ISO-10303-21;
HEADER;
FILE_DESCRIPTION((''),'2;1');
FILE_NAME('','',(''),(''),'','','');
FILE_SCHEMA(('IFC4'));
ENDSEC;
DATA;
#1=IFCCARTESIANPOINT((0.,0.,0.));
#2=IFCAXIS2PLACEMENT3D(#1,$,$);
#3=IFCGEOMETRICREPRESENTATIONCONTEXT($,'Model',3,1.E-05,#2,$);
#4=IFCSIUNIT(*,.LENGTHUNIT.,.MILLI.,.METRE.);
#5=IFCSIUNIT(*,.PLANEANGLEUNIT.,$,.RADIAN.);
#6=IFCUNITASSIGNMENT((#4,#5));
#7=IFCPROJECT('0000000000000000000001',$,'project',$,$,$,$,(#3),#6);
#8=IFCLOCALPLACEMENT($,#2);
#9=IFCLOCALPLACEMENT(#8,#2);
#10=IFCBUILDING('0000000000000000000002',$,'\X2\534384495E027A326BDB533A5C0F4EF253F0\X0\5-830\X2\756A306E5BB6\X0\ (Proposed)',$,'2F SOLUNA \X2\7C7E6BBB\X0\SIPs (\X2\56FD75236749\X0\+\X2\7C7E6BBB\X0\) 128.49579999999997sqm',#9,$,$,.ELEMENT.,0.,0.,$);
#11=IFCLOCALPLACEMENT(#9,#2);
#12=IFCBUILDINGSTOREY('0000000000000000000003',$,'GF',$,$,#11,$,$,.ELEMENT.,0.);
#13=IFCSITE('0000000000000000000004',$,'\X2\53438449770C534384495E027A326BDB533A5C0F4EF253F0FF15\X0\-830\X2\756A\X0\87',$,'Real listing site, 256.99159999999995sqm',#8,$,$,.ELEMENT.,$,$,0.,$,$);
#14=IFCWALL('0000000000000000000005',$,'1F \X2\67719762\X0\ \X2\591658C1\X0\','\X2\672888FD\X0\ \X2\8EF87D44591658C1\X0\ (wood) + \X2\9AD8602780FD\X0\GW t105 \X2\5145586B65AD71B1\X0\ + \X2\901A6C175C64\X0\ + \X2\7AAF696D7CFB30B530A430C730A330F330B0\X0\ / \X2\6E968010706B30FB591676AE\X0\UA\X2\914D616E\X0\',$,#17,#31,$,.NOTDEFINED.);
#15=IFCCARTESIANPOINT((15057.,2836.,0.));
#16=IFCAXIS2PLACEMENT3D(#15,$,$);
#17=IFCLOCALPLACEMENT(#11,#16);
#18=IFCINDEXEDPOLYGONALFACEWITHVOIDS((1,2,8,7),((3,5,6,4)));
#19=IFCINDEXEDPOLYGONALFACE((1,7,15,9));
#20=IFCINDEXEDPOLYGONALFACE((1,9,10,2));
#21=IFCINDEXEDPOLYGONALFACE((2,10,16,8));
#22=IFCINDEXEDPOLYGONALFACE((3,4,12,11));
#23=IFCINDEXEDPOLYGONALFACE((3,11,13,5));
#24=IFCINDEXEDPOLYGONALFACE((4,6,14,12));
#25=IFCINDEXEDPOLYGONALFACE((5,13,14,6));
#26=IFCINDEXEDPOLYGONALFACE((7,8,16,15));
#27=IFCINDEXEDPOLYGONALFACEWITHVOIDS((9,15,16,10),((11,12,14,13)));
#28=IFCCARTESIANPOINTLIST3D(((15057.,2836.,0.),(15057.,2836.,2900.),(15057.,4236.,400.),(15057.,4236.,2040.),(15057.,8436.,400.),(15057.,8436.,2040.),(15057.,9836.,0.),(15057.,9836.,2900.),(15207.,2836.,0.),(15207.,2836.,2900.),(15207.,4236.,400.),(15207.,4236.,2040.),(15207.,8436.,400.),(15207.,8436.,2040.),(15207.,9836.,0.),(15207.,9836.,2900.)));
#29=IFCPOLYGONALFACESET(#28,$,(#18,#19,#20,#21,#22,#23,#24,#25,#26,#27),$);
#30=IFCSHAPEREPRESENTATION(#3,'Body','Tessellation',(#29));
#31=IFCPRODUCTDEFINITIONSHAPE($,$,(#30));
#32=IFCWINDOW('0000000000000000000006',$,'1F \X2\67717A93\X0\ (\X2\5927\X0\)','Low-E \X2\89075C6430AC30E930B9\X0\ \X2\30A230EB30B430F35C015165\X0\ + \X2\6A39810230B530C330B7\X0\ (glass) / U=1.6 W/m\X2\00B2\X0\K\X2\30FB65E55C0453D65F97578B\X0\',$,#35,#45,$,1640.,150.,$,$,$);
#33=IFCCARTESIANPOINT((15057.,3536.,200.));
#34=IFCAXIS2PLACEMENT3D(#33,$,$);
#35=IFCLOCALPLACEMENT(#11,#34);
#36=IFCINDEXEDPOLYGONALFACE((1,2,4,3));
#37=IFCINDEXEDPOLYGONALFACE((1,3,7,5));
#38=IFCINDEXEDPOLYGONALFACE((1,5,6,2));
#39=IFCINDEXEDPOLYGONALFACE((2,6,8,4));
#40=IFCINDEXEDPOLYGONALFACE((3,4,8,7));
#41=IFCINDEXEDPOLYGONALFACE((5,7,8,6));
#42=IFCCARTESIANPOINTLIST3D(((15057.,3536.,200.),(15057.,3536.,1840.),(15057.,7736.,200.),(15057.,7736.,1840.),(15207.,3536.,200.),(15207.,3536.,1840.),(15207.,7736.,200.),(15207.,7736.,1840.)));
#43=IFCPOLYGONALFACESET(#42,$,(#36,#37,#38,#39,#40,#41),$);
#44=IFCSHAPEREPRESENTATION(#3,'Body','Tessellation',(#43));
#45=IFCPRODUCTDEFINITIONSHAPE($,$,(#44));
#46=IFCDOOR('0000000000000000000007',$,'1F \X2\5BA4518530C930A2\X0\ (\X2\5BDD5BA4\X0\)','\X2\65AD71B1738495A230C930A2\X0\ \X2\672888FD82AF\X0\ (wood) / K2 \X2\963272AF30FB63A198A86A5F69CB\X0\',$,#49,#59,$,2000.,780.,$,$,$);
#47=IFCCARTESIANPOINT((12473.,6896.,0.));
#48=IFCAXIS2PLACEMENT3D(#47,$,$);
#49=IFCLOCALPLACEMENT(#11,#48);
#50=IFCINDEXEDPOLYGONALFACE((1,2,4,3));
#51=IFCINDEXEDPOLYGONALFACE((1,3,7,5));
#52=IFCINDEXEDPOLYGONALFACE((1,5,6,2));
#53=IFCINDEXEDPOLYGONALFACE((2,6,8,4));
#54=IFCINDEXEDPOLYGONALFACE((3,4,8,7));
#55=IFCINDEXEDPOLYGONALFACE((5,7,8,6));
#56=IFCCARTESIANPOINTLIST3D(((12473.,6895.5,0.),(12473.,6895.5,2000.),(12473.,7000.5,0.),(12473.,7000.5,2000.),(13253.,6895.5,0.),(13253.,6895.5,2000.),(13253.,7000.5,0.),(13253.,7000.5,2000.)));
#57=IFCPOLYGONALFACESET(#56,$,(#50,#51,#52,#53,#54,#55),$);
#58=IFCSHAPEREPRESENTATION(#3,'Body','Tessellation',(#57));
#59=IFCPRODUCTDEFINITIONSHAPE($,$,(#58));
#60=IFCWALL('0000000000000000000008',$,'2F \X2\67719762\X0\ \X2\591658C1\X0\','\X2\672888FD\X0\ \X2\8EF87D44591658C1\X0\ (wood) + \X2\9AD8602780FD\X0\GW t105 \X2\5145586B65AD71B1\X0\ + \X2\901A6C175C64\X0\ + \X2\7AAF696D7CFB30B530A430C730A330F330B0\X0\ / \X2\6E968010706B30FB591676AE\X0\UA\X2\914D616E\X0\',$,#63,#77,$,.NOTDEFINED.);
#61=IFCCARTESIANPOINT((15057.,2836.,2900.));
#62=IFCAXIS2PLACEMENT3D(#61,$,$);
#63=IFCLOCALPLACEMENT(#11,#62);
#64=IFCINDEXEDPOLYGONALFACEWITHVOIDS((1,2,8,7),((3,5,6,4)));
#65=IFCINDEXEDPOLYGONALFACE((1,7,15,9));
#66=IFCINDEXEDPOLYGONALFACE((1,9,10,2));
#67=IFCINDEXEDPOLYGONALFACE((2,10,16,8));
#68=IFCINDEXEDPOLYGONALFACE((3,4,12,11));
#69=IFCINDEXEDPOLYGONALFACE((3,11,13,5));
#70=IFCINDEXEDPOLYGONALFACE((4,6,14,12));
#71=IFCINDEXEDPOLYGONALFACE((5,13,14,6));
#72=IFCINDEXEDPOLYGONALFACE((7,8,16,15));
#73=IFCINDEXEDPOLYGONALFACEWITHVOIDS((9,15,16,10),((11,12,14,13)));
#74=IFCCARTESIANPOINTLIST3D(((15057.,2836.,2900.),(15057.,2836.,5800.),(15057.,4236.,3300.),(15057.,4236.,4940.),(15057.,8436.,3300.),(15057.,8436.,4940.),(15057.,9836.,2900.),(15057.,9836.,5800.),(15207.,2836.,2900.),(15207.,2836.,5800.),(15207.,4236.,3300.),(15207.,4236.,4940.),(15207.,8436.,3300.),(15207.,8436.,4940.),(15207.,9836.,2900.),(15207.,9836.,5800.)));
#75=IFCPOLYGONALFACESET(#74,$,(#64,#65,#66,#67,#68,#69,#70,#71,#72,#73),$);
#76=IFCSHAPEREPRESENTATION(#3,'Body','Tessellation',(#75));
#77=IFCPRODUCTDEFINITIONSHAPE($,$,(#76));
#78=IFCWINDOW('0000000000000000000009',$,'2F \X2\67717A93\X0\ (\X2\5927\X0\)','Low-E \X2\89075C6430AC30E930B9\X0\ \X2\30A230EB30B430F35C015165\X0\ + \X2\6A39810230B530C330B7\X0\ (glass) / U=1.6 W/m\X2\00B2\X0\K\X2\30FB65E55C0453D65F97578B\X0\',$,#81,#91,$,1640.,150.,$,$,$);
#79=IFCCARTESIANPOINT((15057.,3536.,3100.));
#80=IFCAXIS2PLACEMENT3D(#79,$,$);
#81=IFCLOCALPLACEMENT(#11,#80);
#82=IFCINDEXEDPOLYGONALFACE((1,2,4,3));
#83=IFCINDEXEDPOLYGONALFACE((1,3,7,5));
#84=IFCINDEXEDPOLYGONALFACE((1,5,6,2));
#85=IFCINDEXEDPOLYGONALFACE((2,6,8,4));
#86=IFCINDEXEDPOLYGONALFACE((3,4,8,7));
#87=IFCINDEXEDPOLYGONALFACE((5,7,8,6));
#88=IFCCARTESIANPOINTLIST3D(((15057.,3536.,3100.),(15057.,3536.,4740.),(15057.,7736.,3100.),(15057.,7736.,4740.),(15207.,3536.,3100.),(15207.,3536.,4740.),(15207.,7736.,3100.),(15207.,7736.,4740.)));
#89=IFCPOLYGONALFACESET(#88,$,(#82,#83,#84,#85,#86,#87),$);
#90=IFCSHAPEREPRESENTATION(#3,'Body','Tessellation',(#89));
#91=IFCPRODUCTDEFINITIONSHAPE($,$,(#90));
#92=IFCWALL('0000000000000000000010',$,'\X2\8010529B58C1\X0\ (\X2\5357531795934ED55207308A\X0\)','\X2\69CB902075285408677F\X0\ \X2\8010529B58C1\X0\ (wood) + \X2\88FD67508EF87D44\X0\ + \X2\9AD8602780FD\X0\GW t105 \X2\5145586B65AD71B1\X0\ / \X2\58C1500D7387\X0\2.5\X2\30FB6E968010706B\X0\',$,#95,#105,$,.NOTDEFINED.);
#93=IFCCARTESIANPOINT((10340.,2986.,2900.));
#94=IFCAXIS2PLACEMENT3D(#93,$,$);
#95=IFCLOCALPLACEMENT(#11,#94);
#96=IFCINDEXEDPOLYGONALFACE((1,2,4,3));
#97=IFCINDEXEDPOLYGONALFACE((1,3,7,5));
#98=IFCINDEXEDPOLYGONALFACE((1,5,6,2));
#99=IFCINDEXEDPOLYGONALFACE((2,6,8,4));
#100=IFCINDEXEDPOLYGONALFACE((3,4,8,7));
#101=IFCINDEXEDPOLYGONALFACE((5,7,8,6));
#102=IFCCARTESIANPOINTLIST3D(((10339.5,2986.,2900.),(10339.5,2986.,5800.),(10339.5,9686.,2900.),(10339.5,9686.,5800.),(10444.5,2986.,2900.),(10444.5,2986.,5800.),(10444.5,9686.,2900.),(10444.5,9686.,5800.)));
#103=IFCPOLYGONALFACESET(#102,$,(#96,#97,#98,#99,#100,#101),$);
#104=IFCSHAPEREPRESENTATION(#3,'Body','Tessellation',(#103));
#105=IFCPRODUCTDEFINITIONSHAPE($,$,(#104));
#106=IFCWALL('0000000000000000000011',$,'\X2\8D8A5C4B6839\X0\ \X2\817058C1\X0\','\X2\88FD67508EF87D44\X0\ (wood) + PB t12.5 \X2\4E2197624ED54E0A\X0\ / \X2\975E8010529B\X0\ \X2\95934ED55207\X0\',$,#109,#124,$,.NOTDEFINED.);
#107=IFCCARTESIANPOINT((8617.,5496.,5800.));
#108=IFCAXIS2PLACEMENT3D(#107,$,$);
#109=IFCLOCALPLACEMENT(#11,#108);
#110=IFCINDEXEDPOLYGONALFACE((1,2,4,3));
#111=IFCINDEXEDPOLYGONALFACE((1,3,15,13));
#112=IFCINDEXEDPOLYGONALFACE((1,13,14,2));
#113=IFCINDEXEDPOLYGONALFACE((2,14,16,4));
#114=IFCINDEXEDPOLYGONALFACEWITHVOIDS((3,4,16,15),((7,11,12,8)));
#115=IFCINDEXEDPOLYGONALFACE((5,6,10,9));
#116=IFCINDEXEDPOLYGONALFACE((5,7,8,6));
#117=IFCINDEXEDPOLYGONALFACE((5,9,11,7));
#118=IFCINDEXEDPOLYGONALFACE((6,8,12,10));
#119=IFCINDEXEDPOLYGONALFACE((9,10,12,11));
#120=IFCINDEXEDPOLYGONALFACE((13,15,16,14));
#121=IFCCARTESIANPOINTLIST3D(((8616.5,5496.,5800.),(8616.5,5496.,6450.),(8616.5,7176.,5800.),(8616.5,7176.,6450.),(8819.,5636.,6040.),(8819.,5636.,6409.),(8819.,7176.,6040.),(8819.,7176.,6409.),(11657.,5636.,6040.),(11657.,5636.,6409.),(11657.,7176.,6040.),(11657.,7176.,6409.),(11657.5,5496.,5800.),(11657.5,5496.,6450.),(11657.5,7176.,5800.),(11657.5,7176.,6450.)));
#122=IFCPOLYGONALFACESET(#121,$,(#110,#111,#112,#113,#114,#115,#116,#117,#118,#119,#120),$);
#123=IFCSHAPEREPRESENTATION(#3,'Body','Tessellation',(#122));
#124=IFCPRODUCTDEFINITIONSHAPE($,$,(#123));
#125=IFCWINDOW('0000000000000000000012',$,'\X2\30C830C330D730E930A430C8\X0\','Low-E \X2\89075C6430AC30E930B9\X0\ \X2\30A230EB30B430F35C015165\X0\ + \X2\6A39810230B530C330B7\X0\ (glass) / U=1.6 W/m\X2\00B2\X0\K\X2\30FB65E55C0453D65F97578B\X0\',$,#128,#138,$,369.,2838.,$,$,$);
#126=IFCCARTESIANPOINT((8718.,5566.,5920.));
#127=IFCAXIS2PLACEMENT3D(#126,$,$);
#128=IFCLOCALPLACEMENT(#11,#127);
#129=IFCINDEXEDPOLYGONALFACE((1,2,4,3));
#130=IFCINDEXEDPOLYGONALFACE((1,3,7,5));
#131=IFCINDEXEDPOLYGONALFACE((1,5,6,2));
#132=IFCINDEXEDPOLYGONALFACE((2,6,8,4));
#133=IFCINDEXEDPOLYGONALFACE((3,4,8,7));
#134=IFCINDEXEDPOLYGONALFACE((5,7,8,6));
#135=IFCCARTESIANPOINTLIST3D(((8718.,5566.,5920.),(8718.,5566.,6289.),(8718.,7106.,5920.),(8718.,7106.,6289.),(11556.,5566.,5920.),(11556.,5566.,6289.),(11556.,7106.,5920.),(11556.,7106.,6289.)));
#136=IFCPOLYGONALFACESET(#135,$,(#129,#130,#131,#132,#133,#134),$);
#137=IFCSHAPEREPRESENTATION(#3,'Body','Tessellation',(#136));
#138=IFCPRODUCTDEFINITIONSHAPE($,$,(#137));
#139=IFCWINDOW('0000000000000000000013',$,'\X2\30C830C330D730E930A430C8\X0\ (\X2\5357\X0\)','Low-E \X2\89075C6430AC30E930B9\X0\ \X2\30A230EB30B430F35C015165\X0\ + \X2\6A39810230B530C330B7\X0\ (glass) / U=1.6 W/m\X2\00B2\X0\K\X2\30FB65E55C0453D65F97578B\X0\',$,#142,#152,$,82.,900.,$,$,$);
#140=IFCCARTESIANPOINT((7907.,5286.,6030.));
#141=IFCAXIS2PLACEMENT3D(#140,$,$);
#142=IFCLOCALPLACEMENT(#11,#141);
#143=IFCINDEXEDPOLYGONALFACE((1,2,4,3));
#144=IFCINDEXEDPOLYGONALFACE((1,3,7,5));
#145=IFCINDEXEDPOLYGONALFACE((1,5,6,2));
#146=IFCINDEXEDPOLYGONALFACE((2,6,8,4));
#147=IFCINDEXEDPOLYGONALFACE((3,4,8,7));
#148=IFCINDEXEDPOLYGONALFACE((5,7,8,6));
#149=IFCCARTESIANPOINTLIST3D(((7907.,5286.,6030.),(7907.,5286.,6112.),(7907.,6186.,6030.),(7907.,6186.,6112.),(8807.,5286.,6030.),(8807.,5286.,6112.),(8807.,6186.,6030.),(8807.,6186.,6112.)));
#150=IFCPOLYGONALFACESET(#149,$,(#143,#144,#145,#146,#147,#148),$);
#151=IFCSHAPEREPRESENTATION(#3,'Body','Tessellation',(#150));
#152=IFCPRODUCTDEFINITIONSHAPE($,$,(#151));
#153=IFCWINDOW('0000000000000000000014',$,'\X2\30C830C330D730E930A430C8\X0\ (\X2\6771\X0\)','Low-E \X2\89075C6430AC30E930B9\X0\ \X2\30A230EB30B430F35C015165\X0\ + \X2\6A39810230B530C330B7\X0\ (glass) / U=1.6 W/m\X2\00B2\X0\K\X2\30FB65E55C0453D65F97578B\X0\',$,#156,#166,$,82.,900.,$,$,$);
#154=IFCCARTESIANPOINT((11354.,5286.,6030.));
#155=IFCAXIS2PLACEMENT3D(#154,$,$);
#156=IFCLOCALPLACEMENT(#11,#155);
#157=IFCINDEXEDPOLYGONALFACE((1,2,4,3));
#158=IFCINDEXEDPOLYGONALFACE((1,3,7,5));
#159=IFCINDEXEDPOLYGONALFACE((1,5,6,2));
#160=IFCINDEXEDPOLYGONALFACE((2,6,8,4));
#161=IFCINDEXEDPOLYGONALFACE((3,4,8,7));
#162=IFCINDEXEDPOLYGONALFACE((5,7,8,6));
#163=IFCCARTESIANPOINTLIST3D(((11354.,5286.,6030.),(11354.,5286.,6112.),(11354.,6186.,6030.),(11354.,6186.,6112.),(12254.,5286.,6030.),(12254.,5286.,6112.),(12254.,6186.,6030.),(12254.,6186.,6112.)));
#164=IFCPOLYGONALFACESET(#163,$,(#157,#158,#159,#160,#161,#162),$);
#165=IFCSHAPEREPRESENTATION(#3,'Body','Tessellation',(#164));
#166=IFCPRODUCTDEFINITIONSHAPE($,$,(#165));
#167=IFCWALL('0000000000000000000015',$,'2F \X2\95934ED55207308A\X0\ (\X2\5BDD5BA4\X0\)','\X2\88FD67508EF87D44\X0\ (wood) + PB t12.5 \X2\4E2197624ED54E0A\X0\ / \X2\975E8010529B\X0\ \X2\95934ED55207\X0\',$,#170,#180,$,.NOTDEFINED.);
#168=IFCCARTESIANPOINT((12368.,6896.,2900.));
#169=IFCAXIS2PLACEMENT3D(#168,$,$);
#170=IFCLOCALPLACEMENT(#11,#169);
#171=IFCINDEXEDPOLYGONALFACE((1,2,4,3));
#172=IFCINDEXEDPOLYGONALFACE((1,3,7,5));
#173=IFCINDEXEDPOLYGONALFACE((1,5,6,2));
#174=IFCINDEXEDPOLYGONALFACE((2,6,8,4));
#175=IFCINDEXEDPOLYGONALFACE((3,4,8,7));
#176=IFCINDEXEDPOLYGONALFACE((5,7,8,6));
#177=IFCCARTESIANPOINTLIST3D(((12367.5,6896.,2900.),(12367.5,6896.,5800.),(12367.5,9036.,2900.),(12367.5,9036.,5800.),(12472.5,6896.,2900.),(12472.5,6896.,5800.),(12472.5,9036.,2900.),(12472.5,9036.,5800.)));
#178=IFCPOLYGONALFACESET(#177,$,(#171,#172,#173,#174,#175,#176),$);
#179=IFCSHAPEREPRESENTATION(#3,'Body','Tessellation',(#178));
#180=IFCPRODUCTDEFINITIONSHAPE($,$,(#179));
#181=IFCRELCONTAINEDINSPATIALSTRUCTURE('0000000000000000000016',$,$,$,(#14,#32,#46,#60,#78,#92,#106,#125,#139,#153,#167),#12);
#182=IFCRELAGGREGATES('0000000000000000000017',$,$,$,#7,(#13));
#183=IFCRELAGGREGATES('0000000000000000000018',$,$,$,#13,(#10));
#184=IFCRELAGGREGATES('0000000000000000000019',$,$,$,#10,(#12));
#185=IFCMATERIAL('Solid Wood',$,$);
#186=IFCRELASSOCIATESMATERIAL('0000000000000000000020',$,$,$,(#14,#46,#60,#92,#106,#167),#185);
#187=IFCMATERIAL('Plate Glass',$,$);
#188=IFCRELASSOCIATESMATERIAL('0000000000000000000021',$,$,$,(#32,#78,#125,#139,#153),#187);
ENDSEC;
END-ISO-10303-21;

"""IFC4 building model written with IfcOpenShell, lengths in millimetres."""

from ifc_helpers import new_model, si_unit, frame, frame_2d, origin, place, context, project, spatial, rectangle, extrude, material, element, fill, save


model = new_model("IFC4")

# Units and contexts
model_context = context("Model", 3, precision=1e-05, world=origin())
ifc_project = project(units=[si_unit("LENGTHUNIT", "METRE", prefix="MILLI"), si_unit("PLANEANGLEUNIT", "RADIAN")], contexts=[model_context])

# Site, building, storey
site_placement = place(None, origin())
site = spatial("IfcSite", under=ifc_project, at=site_placement, Name="千葉県千葉市稲毛区小仲台５-830番87", ObjectType="Real listing site, 256.99159999999995sqm", CompositionType="ELEMENT", RefElevation=0.0)
building_placement = place(site_placement, origin())
building = spatial("IfcBuilding", under=site, at=building_placement, Name="千葉市稲毛区小仲台5-830番の家 (Proposed)", ObjectType="2F SOLUNA 籾殻SIPs (国産杉+籾殻) 128.49579999999997sqm", CompositionType="ELEMENT", ElevationOfRefHeight=0.0, ElevationOfTerrain=0.0)
storey_placement = place(building_placement, origin())
storey = spatial("IfcBuildingStorey", under=building, at=storey_placement, Name="GF", CompositionType="ELEMENT", Elevation=0.0)

# Wall, opening, window
ifc_material_1 = material(Name="Solid Wood")
wall_1_placement = place(storey_placement, frame((15057.0, 2836.0, 0.0)))
wall_1 = element("IfcWall", 1, at=wall_1_placement, inside=storey, material=ifc_material_1, Name="1F 東面 外壁", Description="木製 軸組外壁 (wood) + 高性能GW t105 充填断熱 + 通気層 + 窯業系サイディング / 準耐火・外皮UA配慮", PredefinedType="NOTDEFINED", context=model_context, shape_type="SweptSolid", body=[
    extrude(rectangle(XDim=150.0, YDim=7000.0, at=frame_2d((75.0, 3500.0))), frame((15057.0, 2836.0, 0.0)), (0.0, 0.0, 1.0), 2900.0),
])
opening_1_placement = place(storey_placement, frame((15057.0, 3536.0, 200.0)))
opening_1 = element("IfcOpeningElement", 2, at=opening_1_placement, cuts=wall_1, PredefinedType="NOTDEFINED", context=model_context, shape_type="SweptSolid", body=[
    extrude(rectangle(XDim=150.0, YDim=4200.0, at=frame_2d((75.0, 2100.0))), frame((15057.0, 3536.0, 200.0)), (0.0, 0.0, 1.0), 1640.0),
])
ifc_material_2 = material(Name="Plate Glass")
window_1_placement = place(storey_placement, frame((15057.0, 3536.0, 200.0)))
window_1 = element("IfcWindow", 3, at=window_1_placement, inside=storey, material=ifc_material_2, Name="1F 東窓 (大)", Description="Low-E 複層ガラス アルゴン封入 + 樹脂サッシ (glass) / U=1.6 W/m²K・日射取得型", OverallHeight=1640.0, OverallWidth=150.0, context=model_context, shape_type="SweptSolid", body=[
    extrude(rectangle(XDim=150.0, YDim=4200.0, at=frame_2d((75.0, 2100.0))), frame((15057.0, 3536.0, 200.0)), (0.0, 0.0, 1.0), 1640.0),
])
fill(opening_1, window_1)

# Door
door_1_placement = place(storey_placement, frame((12473.0, 6896.0, 0.0)))
element("IfcDoor", 4, at=door_1_placement, inside=storey, material=ifc_material_1, Name="1F 室内ドア (寝室)", Description="断熱玄関ドア 木製芯 (wood) / K2 防犯・採風機構", OverallHeight=2000.0, OverallWidth=780.0, context=model_context, shape_type="SweptSolid", body=[
    extrude(rectangle(XDim=780.0, YDim=105.0, at=frame_2d((390.0, 52.0))), frame((12473.0, 6896.0, 0.0)), (0.0, 0.0, 1.0), 2000.0),
])

# Wall, opening, window
wall_2_placement = place(storey_placement, frame((15057.0, 2836.0, 2900.0)))
wall_2 = element("IfcWall", 5, at=wall_2_placement, inside=storey, material=ifc_material_1, Name="2F 東面 外壁", Description="木製 軸組外壁 (wood) + 高性能GW t105 充填断熱 + 通気層 + 窯業系サイディング / 準耐火・外皮UA配慮", PredefinedType="NOTDEFINED", context=model_context, shape_type="SweptSolid", body=[
    extrude(rectangle(XDim=150.0, YDim=7000.0, at=frame_2d((75.0, 3500.0))), frame((15057.0, 2836.0, 2900.0)), (0.0, 0.0, 1.0), 2900.0),
])
opening_2_placement = place(storey_placement, frame((15057.0, 3536.0, 3100.0)))
opening_2 = element("IfcOpeningElement", 6, at=opening_2_placement, cuts=wall_2, PredefinedType="NOTDEFINED", context=model_context, shape_type="SweptSolid", body=[
    extrude(rectangle(XDim=150.0, YDim=4200.0, at=frame_2d((75.0, 2100.0))), frame((15057.0, 3536.0, 3100.0)), (0.0, 0.0, 1.0), 1640.0),
])
window_2_placement = place(storey_placement, frame((15057.0, 3536.0, 3100.0)))
window_2 = element("IfcWindow", 7, at=window_2_placement, inside=storey, material=ifc_material_2, Name="2F 東窓 (大)", Description="Low-E 複層ガラス アルゴン封入 + 樹脂サッシ (glass) / U=1.6 W/m²K・日射取得型", OverallHeight=1640.0, OverallWidth=150.0, context=model_context, shape_type="SweptSolid", body=[
    extrude(rectangle(XDim=150.0, YDim=4200.0, at=frame_2d((75.0, 2100.0))), frame((15057.0, 3536.0, 3100.0)), (0.0, 0.0, 1.0), 1640.0),
])
fill(opening_2, window_2)

# Wall
wall_3_placement = place(storey_placement, frame((10340.0, 2986.0, 2900.0)))
element("IfcWall", 8, at=wall_3_placement, inside=storey, material=ifc_material_1, Name="耐力壁 (南北間仕切り)", Description="構造用合板 耐力壁 (wood) + 製材軸組 + 高性能GW t105 充填断熱 / 壁倍率2.5・準耐火", PredefinedType="NOTDEFINED", context=model_context, shape_type="SweptSolid", body=[
    extrude(rectangle(XDim=105.0, YDim=6700.0, at=frame_2d((52.0, 3350.0))), frame((10340.0, 2986.0, 2900.0)), (0.0, 0.0, 1.0), 2900.0),
])

# Wall, openings, windows
wall_4_placement = place(storey_placement, frame((8617.0, 5496.0, 5800.0)))
wall_4 = element("IfcWall", 9, at=wall_4_placement, inside=storey, material=ifc_material_1, Name="越屋根 腰壁", Description="製材軸組 (wood) + PB t12.5 両面仕上 / 非耐力 間仕切", PredefinedType="NOTDEFINED", context=model_context, shape_type="SweptSolid", body=[
    extrude(rectangle(XDim=3041.0, YDim=1680.0, at=frame_2d((1520.0, 840.0))), frame((8617.0, 5496.0, 5800.0)), (0.0, 0.0, 1.0), 650.0),
])
opening_3_placement = place(storey_placement, frame((8718.0, 5566.0, 5920.0)))
opening_3 = element("IfcOpeningElement", 10, at=opening_3_placement, cuts=wall_4, PredefinedType="NOTDEFINED", context=model_context, shape_type="SweptSolid", body=[
    extrude(rectangle(XDim=2838.0, YDim=1540.0, at=frame_2d((1419.0, 770.0))), frame((8718.0, 5566.0, 5920.0)), (0.0, 0.0, 1.0), 369.0),
])
opening_4_placement = place(storey_placement, frame((7907.0, 5286.0, 6030.0)))
opening_4 = element("IfcOpeningElement", 11, at=opening_4_placement, cuts=wall_4, PredefinedType="NOTDEFINED", context=model_context, shape_type="SweptSolid", body=[
    extrude(rectangle(XDim=900.0, YDim=900.0, at=frame_2d((450.0, 450.0))), frame((7907.0, 5286.0, 6030.0)), (0.0, 0.0, 1.0), 82.0),
])
opening_5_placement = place(storey_placement, frame((11354.0, 5286.0, 6030.0)))
opening_5 = element("IfcOpeningElement", 12, at=opening_5_placement, cuts=wall_4, PredefinedType="NOTDEFINED", context=model_context, shape_type="SweptSolid", body=[
    extrude(rectangle(XDim=900.0, YDim=900.0, at=frame_2d((450.0, 450.0))), frame((11354.0, 5286.0, 6030.0)), (0.0, 0.0, 1.0), 82.0),
])
window_3_placement = place(storey_placement, frame((8718.0, 5566.0, 5920.0)))
window_3 = element("IfcWindow", 13, at=window_3_placement, inside=storey, material=ifc_material_2, Name="トップライト", Description="Low-E 複層ガラス アルゴン封入 + 樹脂サッシ (glass) / U=1.6 W/m²K・日射取得型", OverallHeight=369.0, OverallWidth=2838.0, context=model_context, shape_type="SweptSolid", body=[
    extrude(rectangle(XDim=2838.0, YDim=1540.0, at=frame_2d((1419.0, 770.0))), frame((8718.0, 5566.0, 5920.0)), (0.0, 0.0, 1.0), 369.0),
])
fill(opening_3, window_3)
window_4_placement = place(storey_placement, frame((7907.0, 5286.0, 6030.0)))
window_4 = element("IfcWindow", 14, at=window_4_placement, inside=storey, material=ifc_material_2, Name="トップライト (南)", Description="Low-E 複層ガラス アルゴン封入 + 樹脂サッシ (glass) / U=1.6 W/m²K・日射取得型", OverallHeight=82.0, OverallWidth=900.0, context=model_context, shape_type="SweptSolid", body=[
    extrude(rectangle(XDim=900.0, YDim=900.0, at=frame_2d((450.0, 450.0))), frame((7907.0, 5286.0, 6030.0)), (0.0, 0.0, 1.0), 82.0),
])
fill(opening_4, window_4)
window_5_placement = place(storey_placement, frame((11354.0, 5286.0, 6030.0)))
window_5 = element("IfcWindow", 15, at=window_5_placement, inside=storey, material=ifc_material_2, Name="トップライト (東)", Description="Low-E 複層ガラス アルゴン封入 + 樹脂サッシ (glass) / U=1.6 W/m²K・日射取得型", OverallHeight=82.0, OverallWidth=900.0, context=model_context, shape_type="SweptSolid", body=[
    extrude(rectangle(XDim=900.0, YDim=900.0, at=frame_2d((450.0, 450.0))), frame((11354.0, 5286.0, 6030.0)), (0.0, 0.0, 1.0), 82.0),
])
fill(opening_5, window_5)

# Wall
wall_5_placement = place(storey_placement, frame((12368.0, 6896.0, 2900.0)))
element("IfcWall", 16, at=wall_5_placement, inside=storey, material=ifc_material_1, Name="2F 間仕切り (寝室)", Description="製材軸組 (wood) + PB t12.5 両面仕上 / 非耐力 間仕切", PredefinedType="NOTDEFINED", context=model_context, shape_type="SweptSolid", body=[
    extrude(rectangle(XDim=105.0, YDim=2140.0, at=frame_2d((52.0, 1070.0))), frame((12368.0, 6896.0, 2900.0)), (0.0, 0.0, 1.0), 2900.0),
])

save(model, "model.ifc")
